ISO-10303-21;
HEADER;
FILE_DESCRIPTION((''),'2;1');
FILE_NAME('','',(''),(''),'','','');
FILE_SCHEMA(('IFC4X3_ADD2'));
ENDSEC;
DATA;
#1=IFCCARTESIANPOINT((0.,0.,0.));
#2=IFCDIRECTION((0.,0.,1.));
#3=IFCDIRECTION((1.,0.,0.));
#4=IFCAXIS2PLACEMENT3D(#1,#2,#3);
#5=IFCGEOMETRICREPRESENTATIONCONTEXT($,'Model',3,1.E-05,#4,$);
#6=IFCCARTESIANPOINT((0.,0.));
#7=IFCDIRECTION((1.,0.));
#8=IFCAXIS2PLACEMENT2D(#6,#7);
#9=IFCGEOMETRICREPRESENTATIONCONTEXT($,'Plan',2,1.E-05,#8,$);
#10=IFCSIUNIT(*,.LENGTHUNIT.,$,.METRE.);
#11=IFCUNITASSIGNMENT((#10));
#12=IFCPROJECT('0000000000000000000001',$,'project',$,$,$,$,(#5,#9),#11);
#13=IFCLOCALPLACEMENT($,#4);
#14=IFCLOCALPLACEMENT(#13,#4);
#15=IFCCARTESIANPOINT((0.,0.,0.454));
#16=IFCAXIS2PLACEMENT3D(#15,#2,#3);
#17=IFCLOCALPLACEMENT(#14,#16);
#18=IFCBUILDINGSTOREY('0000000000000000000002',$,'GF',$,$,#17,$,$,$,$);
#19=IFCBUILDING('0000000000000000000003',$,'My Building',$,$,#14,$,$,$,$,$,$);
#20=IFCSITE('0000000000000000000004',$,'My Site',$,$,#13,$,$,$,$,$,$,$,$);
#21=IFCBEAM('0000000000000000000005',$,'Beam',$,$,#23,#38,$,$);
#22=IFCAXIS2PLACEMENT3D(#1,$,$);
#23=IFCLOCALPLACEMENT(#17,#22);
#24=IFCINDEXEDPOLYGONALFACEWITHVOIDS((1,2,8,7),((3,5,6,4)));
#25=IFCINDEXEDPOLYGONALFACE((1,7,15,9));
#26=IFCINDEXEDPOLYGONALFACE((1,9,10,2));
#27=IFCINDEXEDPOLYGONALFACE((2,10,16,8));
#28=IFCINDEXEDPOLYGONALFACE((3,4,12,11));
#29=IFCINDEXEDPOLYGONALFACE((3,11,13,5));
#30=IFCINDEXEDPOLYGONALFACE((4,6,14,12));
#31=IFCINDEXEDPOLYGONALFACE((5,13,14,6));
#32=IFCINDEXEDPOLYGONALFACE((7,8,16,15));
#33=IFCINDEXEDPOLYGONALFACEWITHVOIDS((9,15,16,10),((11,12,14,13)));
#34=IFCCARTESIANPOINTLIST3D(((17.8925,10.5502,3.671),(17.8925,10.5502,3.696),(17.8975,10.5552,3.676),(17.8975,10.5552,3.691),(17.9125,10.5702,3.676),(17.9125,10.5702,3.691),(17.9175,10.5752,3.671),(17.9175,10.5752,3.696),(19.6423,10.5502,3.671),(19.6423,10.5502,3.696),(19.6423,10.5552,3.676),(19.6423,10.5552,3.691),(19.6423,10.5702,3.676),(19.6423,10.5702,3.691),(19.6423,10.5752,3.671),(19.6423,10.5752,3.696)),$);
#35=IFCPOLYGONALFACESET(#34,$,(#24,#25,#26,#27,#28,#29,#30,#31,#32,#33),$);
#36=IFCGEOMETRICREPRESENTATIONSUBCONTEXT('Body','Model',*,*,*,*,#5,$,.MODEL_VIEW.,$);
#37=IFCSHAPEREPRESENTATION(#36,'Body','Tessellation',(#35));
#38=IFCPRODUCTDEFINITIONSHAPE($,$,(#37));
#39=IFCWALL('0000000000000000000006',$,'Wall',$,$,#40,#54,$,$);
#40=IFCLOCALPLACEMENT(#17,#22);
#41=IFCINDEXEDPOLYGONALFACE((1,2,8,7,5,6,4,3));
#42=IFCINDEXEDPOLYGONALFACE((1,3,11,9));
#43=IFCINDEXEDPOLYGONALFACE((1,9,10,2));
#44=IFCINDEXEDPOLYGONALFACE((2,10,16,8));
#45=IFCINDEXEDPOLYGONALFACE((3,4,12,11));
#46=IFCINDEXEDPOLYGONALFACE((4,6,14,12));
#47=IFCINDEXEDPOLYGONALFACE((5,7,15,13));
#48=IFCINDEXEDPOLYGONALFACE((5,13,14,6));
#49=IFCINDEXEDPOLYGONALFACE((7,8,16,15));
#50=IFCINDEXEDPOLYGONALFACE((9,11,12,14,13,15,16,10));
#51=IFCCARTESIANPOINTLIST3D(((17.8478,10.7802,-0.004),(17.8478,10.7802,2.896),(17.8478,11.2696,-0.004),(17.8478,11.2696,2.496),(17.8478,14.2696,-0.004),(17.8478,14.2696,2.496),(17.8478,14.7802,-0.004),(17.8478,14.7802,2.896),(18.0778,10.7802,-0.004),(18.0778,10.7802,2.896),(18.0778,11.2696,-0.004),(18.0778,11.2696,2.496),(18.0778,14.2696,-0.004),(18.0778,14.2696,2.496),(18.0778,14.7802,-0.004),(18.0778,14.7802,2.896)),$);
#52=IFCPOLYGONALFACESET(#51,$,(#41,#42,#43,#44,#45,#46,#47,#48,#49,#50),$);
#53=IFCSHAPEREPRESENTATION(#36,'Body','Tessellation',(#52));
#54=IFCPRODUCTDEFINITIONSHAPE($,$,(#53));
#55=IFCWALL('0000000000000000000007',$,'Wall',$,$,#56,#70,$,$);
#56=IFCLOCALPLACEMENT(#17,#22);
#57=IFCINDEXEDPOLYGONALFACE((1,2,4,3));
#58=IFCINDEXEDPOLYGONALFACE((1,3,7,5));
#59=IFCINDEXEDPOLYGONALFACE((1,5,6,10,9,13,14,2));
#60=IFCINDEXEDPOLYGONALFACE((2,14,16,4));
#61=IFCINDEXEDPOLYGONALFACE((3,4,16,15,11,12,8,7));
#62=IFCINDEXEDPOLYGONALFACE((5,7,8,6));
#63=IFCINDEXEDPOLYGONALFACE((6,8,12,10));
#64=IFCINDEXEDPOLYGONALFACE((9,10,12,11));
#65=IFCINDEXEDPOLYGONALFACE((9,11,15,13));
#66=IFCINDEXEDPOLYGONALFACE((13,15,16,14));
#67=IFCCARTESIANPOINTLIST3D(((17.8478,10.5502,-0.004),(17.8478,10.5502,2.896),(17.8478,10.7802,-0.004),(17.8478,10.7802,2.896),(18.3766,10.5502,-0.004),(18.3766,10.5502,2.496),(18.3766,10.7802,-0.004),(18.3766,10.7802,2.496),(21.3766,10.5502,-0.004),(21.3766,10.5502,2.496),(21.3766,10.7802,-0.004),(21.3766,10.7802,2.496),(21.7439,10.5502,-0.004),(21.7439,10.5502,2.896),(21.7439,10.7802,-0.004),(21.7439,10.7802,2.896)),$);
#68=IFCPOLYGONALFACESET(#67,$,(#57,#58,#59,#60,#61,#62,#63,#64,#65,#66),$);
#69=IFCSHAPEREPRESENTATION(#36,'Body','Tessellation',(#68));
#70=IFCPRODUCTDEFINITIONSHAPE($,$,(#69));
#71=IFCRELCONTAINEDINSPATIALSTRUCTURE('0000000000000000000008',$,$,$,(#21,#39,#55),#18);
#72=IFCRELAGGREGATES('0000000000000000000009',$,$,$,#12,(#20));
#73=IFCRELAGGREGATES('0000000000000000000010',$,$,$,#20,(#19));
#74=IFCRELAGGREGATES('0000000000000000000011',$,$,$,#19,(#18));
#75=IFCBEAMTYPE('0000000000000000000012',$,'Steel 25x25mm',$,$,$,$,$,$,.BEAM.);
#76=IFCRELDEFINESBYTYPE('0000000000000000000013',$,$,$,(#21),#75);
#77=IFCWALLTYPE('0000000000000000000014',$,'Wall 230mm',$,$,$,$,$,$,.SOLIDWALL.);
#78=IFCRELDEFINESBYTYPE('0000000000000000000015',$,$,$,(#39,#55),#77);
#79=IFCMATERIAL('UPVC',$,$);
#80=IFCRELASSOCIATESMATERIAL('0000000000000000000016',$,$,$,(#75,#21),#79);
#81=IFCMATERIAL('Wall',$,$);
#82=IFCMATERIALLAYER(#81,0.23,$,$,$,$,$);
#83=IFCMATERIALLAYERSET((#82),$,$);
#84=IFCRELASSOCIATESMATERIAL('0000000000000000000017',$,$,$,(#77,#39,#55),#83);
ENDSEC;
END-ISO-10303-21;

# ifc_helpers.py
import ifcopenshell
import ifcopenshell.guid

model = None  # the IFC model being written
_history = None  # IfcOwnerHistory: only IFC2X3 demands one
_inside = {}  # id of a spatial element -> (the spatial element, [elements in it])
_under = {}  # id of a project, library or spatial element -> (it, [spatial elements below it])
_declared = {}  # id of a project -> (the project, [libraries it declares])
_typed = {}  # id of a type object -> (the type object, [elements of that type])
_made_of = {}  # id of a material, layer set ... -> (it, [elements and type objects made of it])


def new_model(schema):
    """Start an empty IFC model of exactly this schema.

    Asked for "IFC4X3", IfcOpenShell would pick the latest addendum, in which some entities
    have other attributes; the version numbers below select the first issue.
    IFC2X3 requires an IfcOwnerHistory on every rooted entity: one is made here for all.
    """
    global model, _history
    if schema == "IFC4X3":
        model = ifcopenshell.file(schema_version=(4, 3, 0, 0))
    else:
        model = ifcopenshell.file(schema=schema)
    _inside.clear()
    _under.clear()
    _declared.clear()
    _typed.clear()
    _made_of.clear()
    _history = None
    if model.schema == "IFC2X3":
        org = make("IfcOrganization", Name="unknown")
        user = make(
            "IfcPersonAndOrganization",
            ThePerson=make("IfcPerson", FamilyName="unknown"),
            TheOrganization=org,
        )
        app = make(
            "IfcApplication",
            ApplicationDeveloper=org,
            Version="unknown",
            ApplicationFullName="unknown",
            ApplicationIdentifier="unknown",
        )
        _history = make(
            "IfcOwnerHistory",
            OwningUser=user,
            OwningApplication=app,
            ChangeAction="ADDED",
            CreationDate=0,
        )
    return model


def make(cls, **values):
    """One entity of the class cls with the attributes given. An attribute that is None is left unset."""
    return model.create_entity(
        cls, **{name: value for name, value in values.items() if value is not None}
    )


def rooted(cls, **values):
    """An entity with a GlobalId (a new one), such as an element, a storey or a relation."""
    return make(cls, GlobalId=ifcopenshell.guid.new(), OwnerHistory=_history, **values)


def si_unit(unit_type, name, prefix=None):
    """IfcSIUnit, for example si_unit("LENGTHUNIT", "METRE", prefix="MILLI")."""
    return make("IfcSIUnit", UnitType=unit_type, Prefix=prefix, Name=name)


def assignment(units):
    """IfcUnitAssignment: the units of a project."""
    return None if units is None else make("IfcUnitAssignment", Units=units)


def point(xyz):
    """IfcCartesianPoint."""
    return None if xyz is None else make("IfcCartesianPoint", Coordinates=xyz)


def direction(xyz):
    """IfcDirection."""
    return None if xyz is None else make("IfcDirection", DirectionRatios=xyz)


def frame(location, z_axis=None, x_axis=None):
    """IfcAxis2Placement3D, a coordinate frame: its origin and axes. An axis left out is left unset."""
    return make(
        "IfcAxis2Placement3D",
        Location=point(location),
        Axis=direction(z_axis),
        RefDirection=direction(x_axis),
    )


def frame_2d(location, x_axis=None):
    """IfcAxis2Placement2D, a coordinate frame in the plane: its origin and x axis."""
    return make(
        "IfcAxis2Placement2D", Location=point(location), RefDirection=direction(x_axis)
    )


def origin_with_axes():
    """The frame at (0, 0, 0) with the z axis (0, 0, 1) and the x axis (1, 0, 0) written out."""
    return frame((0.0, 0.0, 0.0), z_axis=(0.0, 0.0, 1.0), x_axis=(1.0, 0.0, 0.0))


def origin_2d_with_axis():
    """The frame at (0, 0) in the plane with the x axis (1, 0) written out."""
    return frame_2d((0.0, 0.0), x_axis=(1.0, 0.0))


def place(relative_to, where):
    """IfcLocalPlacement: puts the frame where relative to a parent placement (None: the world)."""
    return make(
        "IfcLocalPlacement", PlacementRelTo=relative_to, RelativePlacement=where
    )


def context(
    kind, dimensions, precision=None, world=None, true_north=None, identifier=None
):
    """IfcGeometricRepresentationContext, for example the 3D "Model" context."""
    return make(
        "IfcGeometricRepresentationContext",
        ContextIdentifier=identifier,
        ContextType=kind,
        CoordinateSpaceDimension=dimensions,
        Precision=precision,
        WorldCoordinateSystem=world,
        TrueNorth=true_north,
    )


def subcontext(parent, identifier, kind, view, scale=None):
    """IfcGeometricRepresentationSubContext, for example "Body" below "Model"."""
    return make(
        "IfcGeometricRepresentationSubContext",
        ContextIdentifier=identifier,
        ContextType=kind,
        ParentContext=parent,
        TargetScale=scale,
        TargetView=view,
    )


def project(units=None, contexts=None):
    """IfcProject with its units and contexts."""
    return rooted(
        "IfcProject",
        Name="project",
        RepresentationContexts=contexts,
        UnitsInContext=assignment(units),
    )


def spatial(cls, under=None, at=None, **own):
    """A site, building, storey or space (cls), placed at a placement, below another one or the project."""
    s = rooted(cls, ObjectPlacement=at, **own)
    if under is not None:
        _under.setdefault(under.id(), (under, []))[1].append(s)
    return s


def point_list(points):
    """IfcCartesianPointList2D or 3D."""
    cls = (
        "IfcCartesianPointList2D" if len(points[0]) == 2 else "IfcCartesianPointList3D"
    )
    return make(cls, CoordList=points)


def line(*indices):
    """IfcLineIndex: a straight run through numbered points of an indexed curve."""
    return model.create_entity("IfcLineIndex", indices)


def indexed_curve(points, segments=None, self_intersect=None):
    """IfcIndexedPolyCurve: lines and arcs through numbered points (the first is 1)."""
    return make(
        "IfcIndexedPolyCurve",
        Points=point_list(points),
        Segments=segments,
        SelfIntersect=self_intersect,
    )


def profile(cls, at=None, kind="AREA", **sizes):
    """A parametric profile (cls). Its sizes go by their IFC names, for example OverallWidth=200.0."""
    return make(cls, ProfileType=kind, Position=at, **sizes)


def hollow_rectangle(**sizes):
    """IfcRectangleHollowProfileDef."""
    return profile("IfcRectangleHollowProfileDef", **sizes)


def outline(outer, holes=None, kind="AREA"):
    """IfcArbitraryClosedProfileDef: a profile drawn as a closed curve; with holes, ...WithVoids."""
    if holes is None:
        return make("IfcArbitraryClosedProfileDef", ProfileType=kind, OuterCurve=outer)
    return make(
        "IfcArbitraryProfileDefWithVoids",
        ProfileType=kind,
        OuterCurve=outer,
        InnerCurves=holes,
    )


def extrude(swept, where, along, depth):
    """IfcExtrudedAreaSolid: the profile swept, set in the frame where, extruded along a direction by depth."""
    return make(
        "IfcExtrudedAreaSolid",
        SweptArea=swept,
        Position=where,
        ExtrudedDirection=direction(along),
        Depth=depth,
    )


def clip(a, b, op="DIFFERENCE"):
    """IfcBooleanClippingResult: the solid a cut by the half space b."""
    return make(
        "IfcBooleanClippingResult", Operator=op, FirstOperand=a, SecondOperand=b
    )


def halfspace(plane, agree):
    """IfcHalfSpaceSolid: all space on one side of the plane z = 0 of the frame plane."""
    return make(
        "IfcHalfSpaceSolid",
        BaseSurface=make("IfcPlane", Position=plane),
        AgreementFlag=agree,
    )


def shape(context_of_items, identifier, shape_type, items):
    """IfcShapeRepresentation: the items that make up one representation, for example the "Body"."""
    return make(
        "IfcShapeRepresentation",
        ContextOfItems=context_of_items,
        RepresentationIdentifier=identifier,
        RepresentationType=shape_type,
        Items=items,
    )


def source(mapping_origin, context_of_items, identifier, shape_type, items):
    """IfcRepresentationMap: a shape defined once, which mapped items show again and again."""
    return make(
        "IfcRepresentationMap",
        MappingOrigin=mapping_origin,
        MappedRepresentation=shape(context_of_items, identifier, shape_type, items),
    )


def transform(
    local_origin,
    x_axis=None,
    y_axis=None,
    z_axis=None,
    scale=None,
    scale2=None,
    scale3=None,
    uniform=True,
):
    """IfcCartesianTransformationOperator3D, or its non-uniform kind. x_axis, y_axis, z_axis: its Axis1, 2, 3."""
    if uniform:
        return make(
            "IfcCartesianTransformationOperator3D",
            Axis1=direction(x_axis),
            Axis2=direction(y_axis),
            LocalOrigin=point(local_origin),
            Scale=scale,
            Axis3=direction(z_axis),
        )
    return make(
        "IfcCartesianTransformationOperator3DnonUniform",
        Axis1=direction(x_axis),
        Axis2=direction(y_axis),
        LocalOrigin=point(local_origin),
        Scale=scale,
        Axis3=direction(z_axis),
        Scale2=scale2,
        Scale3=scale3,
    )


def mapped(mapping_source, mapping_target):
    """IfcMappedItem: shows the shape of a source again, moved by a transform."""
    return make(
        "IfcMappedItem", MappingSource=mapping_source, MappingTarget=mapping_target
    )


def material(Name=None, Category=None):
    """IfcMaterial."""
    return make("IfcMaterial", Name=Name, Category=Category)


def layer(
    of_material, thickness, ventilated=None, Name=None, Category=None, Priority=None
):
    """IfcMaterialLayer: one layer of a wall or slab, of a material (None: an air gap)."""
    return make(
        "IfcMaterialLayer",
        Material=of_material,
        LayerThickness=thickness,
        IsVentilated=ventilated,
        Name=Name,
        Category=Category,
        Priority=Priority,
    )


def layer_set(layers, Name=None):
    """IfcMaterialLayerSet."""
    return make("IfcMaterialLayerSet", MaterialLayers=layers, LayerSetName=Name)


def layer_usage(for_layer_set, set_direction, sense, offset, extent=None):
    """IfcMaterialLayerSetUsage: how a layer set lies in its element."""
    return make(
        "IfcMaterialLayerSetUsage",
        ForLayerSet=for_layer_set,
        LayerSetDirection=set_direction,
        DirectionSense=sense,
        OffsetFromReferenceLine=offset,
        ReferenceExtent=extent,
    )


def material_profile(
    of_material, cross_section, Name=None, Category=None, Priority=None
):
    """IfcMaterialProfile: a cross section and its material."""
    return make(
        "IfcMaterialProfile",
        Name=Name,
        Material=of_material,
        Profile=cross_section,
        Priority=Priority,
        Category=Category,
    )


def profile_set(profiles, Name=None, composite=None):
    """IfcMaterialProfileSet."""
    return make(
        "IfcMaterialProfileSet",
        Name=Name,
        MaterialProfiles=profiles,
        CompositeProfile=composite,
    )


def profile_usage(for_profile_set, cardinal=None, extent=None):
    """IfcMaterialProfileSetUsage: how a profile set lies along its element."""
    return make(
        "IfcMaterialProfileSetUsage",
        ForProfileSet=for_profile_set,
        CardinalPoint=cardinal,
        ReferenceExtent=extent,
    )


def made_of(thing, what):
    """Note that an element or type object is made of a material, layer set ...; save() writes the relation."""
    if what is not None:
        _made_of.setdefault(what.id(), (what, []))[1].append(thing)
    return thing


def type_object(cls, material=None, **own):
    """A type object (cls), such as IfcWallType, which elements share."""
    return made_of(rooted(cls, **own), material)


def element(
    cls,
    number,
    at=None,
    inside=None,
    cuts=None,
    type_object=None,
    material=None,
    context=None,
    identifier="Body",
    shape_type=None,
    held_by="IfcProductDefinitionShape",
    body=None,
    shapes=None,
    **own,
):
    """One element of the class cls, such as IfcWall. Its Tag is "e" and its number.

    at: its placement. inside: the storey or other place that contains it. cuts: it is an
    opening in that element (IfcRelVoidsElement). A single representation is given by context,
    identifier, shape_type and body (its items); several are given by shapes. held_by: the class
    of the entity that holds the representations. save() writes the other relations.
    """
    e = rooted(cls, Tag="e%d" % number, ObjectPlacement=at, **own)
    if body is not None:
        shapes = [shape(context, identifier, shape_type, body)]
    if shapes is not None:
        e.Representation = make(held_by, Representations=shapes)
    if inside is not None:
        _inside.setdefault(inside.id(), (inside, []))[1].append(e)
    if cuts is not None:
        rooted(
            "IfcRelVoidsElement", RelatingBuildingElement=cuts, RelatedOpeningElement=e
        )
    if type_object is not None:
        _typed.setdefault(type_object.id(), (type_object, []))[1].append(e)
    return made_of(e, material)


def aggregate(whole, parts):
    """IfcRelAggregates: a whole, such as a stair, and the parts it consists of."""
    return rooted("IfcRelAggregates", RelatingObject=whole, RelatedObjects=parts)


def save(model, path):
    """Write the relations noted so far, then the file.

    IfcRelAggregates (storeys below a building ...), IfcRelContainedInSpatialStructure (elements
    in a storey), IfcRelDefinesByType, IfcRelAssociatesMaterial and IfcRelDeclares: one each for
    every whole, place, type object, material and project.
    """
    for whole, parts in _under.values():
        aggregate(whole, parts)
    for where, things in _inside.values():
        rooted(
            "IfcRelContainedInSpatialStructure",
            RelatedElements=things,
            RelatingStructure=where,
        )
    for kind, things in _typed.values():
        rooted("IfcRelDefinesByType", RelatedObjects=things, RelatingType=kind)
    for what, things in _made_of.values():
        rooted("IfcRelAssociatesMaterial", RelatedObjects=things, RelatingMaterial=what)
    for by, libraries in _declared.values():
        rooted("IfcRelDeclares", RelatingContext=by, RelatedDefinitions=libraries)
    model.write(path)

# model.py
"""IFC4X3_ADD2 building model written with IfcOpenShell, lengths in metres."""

from ifc_helpers import new_model, si_unit, frame, origin_with_axes, origin_2d_with_axis, place, context, subcontext, project, spatial, line, indexed_curve, hollow_rectangle, outline, extrude, clip, halfspace, source, transform, mapped, material, layer, layer_set, layer_usage, material_profile, profile_set, profile_usage, type_object, element, save


model = new_model("IFC4X3_ADD2")

# Units and contexts
model_context = context("Model", 3, precision=1e-05, world=origin_with_axes())
plan_context = context("Plan", 2, precision=1e-05, world=origin_2d_with_axis())
body_context = subcontext(model_context, "Body", "Model", "MODEL_VIEW")
ifc_project = project(units=[si_unit("LENGTHUNIT", "METRE")], contexts=[model_context, plan_context])

# Site, building, storey
site_placement = place(None, origin_with_axes())
site = spatial("IfcSite", under=ifc_project, at=site_placement, Name="My Site")
building_placement = place(site_placement, origin_with_axes())
building = spatial("IfcBuilding", under=site, at=building_placement, Name="My Building")
storey_placement = place(building_placement, frame((0.0, 0.0, 0.454), z_axis=(0.0, 0.0, 1.0), x_axis=(1.0, 0.0, 0.0)))
storey = spatial("IfcBuildingStorey", under=building, at=storey_placement, Name="GF")

# Shared definitions
ifc_material_1 = material(Name="UPVC")

# Beam
ifc_material_profile_1 = material_profile(ifc_material_1, hollow_rectangle(XDim=0.025, YDim=0.025, WallThickness=0.005))
ifc_profile_set_1 = profile_set([ifc_material_profile_1])
ifc_profile_usage_1 = profile_usage(ifc_profile_set_1)
beam_type = type_object("IfcBeamType", Name="Steel 25x25mm", PredefinedType="BEAM", material=ifc_profile_set_1)
beam_placement = place(storey_placement, frame((17.8925, 10.5627, 3.6835), z_axis=(1.0, 0.0, 0.0), x_axis=(0.0, 1.0, 0.0)))
element("IfcBeam", 1, at=beam_placement, inside=storey, type_object=beam_type, material=ifc_profile_usage_1, Name="Beam", context=body_context, shape_type="Clipping", body=[
    clip(extrude(hollow_rectangle(XDim=0.025, YDim=0.025, WallThickness=0.005), origin_with_axes(), (0.0, 0.0, 1.0), 1.7497), halfspace(frame((-0.0125, -4.1375, 0.0), z_axis=(0.707134, 0.0, -0.70708), x_axis=(0.0, -1.0, 0.0)), False)),
])

# Walls, openings
ifc_material_2 = material(Name="Wall")
ifc_layer = layer(ifc_material_2, 0.23)
ifc_layer_set = layer_set([ifc_layer])
ifc_layer_usage_1 = layer_usage(ifc_layer_set, "AXIS2", "POSITIVE", 0.0)
wall_type = type_object("IfcWallType", Name="Wall 230mm", PredefinedType="SOLIDWALL", material=ifc_layer_set)
wall_1_placement = place(storey_placement, frame((18.0778, 10.7802, -0.004), z_axis=(0.0, 0.0, 1.0), x_axis=(0.000001, 1.0, 0.0)))
wall_1 = element("IfcWall", 2, at=wall_1_placement, inside=storey, type_object=wall_type, material=ifc_layer_usage_1, Name="Wall", context=body_context, shape_type="SweptSolid", body=[
    extrude(outline(indexed_curve([(0.0, 0.0), (0.0, 0.23), (4.0, 0.23), (4.0, 0.0), (0.0, 0.0)], self_intersect=False)), origin_with_axes(), (0.0, 0.0, 1.0), 2.9),
])
shared_shape = source(origin_with_axes(), body_context, "Body", "SweptSolid", [
    extrude(outline(indexed_curve([(0.0, 0.0), (3.0, 0.0), (3.0, 2.5), (0.0, 2.5)], segments=[line(1, 2, 3, 4, 1)])), frame((0.0, -0.6, 0.0), z_axis=(0.0, -1.0, 0.0), x_axis=(1.0, 0.0, 0.0)), (0.0, 0.0, -1.0), 1.2),
])
opening_1_placement = place(wall_1_placement, frame((0.4894, 0.0, 0.0), z_axis=(0.0, 0.0, 1.0), x_axis=(1.0, 0.0, 0.0)))
element("IfcOpeningElement", 3, at=opening_1_placement, cuts=wall_1, PredefinedType="OPENING", context=body_context, shape_type="MappedRepresentation", body=[
    mapped(shared_shape, transform((0.0, 0.0, 0.0), x_axis=(1.0, 0.0, 0.0), y_axis=(0.0, 1.0, 0.0), z_axis=(0.0, 0.0, 1.0), scale=1.0)),
])
ifc_layer_usage_2 = layer_usage(ifc_layer_set, "AXIS2", "POSITIVE", 0.0)
wall_2_placement = place(storey_placement, frame((21.7439, 10.7802, -0.004), z_axis=(0.0, 0.0, 1.0), x_axis=(-1.0, 0.0, 0.0)))
wall_2 = element("IfcWall", 4, at=wall_2_placement, inside=storey, type_object=wall_type, material=ifc_layer_usage_2, Name="Wall", context=body_context, shape_type="SweptSolid", body=[
    extrude(outline(indexed_curve([(0.0, 0.0), (0.0, 0.23), (3.8962, 0.23), (3.8962, 0.0), (0.0, 0.0)], self_intersect=False)), origin_with_axes(), (0.0, 0.0, 1.0), 2.9),
])
opening_2_placement = place(wall_2_placement, frame((0.3674, 0.0, 0.0), z_axis=(0.0, 0.0, 1.0), x_axis=(1.0, 0.0, 0.0)))
element("IfcOpeningElement", 5, at=opening_2_placement, cuts=wall_2, PredefinedType="OPENING", context=body_context, shape_type="MappedRepresentation", body=[
    mapped(shared_shape, transform((0.0, 0.0, 0.0), x_axis=(1.0, 0.0, 0.0), y_axis=(0.0, 1.0, 0.0), z_axis=(0.0, 0.0, 1.0), scale=1.0)),
])

save(model, "model.ifc")
